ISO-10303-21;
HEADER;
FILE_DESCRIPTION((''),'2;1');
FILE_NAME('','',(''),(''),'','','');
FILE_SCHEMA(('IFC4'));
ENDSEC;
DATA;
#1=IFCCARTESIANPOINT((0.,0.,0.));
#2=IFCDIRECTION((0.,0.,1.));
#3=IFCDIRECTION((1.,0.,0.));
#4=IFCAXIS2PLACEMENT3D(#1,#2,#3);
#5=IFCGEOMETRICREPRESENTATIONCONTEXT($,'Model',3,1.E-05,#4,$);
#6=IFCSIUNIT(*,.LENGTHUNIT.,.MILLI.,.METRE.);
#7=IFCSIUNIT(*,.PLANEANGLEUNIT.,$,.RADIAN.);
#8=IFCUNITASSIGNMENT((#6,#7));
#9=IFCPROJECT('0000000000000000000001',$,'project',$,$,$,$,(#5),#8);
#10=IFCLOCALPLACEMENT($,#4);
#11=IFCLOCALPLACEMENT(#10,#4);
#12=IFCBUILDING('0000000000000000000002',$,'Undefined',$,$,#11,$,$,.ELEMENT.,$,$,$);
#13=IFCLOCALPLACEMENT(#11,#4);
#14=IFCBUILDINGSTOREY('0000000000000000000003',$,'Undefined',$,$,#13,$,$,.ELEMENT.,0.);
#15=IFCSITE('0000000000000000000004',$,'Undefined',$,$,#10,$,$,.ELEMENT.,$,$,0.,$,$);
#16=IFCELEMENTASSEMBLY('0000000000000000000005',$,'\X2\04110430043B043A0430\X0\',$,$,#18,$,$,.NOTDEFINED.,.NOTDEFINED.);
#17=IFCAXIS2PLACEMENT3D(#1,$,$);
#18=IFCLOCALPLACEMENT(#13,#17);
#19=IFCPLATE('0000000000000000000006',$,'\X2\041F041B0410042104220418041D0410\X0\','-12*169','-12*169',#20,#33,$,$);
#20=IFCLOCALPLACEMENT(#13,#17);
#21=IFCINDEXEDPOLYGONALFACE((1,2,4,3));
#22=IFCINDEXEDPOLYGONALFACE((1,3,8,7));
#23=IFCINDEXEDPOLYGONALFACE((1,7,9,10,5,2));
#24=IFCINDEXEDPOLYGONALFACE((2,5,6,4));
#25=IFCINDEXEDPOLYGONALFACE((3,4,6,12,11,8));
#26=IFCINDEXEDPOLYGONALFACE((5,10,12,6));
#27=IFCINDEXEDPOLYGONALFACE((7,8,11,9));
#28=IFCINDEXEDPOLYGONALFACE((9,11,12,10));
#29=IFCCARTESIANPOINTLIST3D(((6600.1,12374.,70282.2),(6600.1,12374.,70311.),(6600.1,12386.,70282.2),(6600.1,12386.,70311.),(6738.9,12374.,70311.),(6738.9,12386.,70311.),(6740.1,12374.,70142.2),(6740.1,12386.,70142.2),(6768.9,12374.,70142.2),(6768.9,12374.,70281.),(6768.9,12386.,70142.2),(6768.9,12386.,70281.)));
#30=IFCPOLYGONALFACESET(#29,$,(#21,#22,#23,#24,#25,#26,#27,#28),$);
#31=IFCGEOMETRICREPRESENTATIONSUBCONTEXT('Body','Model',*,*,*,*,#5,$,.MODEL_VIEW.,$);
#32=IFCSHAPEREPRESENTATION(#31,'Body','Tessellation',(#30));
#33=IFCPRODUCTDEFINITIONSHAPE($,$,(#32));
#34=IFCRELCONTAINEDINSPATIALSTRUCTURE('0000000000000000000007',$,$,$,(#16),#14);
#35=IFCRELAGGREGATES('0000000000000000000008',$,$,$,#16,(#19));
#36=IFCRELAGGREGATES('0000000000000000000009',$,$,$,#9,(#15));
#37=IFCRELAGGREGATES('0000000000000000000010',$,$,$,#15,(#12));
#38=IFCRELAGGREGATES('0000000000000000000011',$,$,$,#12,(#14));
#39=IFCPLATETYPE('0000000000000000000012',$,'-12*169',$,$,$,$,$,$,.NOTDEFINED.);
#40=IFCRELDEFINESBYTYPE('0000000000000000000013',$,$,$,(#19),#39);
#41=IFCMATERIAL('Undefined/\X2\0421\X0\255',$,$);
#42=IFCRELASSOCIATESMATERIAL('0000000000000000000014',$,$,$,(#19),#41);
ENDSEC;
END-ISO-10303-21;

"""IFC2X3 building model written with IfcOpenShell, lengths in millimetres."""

from ifc_helpers import new_model, si_unit, frame, origin_with_axes, place, context, subcontext, project, spatial, polyline, outline, extrude, material, type_object, element, aggregate, save


model = new_model("IFC2X3")

# Units and contexts
model_context = context("Model", 3, precision=1e-05, world=origin_with_axes())
body_context = subcontext(model_context, "Body", "Model", "MODEL_VIEW")
ifc_project = project(units=[si_unit("LENGTHUNIT", "METRE", prefix="MILLI"), si_unit("PLANEANGLEUNIT", "RADIAN")], contexts=[model_context])

# Site, building, storey
site_placement = place(None, origin_with_axes())
site = spatial("IfcSite", under=ifc_project, at=site_placement, Name="Undefined", CompositionType="ELEMENT", RefElevation=0.0)
building_placement = place(site_placement, origin_with_axes())
building = spatial("IfcBuilding", under=site, at=building_placement, Name="Undefined", CompositionType="ELEMENT")
storey_placement = place(building_placement, origin_with_axes())
storey = spatial("IfcBuildingStorey", under=building, at=storey_placement, Name="Undefined", CompositionType="ELEMENT", Elevation=0.0)

# Shared definitions
ifc_material_1 = material(Name="Undefined/С255")

# Element assembly, plate
assembly_1_placement = place(storey_placement, origin_with_axes())
assembly_1 = element("IfcElementAssembly", 1, at=assembly_1_placement, inside=storey, Name="Балка", AssemblyPlace="NOTDEFINED", PredefinedType="NOTDEFINED")
plate_type_1 = type_object("IfcPlateType", Name="-12*169", PredefinedType="NOTDEFINED")
plate_1_placement = place(assembly_1_placement, frame((6600.1, 12380.0, 70142.2), z_axis=(0.0, 1.0, 0.0), x_axis=(0.0, 0.0, 1.0)))
plate_1 = element("IfcPlate", 2, at=plate_1_placement, type_object=plate_type_1, material=ifc_material_1, Name="ПЛАСТИНА", Description="-12*169", ObjectType="-12*169", context=body_context, shape_type="SweptSolid", body=[
    extrude(outline(polyline([(0.0, 140.0), (140.0, 0.0), (168.8, 0.0), (168.8, 138.8), (138.8, 168.8), (0.0, 168.8), (0.0, 140.0)])), frame((0.0, 0.0, -6.0), z_axis=(0.0, 0.0, 1.0), x_axis=(1.0, 0.0, 0.0)), (0.0, 0.0, 1.0), 12.0),
])
aggregate(assembly_1, [plate_1])

save(model, "model.ifc")
